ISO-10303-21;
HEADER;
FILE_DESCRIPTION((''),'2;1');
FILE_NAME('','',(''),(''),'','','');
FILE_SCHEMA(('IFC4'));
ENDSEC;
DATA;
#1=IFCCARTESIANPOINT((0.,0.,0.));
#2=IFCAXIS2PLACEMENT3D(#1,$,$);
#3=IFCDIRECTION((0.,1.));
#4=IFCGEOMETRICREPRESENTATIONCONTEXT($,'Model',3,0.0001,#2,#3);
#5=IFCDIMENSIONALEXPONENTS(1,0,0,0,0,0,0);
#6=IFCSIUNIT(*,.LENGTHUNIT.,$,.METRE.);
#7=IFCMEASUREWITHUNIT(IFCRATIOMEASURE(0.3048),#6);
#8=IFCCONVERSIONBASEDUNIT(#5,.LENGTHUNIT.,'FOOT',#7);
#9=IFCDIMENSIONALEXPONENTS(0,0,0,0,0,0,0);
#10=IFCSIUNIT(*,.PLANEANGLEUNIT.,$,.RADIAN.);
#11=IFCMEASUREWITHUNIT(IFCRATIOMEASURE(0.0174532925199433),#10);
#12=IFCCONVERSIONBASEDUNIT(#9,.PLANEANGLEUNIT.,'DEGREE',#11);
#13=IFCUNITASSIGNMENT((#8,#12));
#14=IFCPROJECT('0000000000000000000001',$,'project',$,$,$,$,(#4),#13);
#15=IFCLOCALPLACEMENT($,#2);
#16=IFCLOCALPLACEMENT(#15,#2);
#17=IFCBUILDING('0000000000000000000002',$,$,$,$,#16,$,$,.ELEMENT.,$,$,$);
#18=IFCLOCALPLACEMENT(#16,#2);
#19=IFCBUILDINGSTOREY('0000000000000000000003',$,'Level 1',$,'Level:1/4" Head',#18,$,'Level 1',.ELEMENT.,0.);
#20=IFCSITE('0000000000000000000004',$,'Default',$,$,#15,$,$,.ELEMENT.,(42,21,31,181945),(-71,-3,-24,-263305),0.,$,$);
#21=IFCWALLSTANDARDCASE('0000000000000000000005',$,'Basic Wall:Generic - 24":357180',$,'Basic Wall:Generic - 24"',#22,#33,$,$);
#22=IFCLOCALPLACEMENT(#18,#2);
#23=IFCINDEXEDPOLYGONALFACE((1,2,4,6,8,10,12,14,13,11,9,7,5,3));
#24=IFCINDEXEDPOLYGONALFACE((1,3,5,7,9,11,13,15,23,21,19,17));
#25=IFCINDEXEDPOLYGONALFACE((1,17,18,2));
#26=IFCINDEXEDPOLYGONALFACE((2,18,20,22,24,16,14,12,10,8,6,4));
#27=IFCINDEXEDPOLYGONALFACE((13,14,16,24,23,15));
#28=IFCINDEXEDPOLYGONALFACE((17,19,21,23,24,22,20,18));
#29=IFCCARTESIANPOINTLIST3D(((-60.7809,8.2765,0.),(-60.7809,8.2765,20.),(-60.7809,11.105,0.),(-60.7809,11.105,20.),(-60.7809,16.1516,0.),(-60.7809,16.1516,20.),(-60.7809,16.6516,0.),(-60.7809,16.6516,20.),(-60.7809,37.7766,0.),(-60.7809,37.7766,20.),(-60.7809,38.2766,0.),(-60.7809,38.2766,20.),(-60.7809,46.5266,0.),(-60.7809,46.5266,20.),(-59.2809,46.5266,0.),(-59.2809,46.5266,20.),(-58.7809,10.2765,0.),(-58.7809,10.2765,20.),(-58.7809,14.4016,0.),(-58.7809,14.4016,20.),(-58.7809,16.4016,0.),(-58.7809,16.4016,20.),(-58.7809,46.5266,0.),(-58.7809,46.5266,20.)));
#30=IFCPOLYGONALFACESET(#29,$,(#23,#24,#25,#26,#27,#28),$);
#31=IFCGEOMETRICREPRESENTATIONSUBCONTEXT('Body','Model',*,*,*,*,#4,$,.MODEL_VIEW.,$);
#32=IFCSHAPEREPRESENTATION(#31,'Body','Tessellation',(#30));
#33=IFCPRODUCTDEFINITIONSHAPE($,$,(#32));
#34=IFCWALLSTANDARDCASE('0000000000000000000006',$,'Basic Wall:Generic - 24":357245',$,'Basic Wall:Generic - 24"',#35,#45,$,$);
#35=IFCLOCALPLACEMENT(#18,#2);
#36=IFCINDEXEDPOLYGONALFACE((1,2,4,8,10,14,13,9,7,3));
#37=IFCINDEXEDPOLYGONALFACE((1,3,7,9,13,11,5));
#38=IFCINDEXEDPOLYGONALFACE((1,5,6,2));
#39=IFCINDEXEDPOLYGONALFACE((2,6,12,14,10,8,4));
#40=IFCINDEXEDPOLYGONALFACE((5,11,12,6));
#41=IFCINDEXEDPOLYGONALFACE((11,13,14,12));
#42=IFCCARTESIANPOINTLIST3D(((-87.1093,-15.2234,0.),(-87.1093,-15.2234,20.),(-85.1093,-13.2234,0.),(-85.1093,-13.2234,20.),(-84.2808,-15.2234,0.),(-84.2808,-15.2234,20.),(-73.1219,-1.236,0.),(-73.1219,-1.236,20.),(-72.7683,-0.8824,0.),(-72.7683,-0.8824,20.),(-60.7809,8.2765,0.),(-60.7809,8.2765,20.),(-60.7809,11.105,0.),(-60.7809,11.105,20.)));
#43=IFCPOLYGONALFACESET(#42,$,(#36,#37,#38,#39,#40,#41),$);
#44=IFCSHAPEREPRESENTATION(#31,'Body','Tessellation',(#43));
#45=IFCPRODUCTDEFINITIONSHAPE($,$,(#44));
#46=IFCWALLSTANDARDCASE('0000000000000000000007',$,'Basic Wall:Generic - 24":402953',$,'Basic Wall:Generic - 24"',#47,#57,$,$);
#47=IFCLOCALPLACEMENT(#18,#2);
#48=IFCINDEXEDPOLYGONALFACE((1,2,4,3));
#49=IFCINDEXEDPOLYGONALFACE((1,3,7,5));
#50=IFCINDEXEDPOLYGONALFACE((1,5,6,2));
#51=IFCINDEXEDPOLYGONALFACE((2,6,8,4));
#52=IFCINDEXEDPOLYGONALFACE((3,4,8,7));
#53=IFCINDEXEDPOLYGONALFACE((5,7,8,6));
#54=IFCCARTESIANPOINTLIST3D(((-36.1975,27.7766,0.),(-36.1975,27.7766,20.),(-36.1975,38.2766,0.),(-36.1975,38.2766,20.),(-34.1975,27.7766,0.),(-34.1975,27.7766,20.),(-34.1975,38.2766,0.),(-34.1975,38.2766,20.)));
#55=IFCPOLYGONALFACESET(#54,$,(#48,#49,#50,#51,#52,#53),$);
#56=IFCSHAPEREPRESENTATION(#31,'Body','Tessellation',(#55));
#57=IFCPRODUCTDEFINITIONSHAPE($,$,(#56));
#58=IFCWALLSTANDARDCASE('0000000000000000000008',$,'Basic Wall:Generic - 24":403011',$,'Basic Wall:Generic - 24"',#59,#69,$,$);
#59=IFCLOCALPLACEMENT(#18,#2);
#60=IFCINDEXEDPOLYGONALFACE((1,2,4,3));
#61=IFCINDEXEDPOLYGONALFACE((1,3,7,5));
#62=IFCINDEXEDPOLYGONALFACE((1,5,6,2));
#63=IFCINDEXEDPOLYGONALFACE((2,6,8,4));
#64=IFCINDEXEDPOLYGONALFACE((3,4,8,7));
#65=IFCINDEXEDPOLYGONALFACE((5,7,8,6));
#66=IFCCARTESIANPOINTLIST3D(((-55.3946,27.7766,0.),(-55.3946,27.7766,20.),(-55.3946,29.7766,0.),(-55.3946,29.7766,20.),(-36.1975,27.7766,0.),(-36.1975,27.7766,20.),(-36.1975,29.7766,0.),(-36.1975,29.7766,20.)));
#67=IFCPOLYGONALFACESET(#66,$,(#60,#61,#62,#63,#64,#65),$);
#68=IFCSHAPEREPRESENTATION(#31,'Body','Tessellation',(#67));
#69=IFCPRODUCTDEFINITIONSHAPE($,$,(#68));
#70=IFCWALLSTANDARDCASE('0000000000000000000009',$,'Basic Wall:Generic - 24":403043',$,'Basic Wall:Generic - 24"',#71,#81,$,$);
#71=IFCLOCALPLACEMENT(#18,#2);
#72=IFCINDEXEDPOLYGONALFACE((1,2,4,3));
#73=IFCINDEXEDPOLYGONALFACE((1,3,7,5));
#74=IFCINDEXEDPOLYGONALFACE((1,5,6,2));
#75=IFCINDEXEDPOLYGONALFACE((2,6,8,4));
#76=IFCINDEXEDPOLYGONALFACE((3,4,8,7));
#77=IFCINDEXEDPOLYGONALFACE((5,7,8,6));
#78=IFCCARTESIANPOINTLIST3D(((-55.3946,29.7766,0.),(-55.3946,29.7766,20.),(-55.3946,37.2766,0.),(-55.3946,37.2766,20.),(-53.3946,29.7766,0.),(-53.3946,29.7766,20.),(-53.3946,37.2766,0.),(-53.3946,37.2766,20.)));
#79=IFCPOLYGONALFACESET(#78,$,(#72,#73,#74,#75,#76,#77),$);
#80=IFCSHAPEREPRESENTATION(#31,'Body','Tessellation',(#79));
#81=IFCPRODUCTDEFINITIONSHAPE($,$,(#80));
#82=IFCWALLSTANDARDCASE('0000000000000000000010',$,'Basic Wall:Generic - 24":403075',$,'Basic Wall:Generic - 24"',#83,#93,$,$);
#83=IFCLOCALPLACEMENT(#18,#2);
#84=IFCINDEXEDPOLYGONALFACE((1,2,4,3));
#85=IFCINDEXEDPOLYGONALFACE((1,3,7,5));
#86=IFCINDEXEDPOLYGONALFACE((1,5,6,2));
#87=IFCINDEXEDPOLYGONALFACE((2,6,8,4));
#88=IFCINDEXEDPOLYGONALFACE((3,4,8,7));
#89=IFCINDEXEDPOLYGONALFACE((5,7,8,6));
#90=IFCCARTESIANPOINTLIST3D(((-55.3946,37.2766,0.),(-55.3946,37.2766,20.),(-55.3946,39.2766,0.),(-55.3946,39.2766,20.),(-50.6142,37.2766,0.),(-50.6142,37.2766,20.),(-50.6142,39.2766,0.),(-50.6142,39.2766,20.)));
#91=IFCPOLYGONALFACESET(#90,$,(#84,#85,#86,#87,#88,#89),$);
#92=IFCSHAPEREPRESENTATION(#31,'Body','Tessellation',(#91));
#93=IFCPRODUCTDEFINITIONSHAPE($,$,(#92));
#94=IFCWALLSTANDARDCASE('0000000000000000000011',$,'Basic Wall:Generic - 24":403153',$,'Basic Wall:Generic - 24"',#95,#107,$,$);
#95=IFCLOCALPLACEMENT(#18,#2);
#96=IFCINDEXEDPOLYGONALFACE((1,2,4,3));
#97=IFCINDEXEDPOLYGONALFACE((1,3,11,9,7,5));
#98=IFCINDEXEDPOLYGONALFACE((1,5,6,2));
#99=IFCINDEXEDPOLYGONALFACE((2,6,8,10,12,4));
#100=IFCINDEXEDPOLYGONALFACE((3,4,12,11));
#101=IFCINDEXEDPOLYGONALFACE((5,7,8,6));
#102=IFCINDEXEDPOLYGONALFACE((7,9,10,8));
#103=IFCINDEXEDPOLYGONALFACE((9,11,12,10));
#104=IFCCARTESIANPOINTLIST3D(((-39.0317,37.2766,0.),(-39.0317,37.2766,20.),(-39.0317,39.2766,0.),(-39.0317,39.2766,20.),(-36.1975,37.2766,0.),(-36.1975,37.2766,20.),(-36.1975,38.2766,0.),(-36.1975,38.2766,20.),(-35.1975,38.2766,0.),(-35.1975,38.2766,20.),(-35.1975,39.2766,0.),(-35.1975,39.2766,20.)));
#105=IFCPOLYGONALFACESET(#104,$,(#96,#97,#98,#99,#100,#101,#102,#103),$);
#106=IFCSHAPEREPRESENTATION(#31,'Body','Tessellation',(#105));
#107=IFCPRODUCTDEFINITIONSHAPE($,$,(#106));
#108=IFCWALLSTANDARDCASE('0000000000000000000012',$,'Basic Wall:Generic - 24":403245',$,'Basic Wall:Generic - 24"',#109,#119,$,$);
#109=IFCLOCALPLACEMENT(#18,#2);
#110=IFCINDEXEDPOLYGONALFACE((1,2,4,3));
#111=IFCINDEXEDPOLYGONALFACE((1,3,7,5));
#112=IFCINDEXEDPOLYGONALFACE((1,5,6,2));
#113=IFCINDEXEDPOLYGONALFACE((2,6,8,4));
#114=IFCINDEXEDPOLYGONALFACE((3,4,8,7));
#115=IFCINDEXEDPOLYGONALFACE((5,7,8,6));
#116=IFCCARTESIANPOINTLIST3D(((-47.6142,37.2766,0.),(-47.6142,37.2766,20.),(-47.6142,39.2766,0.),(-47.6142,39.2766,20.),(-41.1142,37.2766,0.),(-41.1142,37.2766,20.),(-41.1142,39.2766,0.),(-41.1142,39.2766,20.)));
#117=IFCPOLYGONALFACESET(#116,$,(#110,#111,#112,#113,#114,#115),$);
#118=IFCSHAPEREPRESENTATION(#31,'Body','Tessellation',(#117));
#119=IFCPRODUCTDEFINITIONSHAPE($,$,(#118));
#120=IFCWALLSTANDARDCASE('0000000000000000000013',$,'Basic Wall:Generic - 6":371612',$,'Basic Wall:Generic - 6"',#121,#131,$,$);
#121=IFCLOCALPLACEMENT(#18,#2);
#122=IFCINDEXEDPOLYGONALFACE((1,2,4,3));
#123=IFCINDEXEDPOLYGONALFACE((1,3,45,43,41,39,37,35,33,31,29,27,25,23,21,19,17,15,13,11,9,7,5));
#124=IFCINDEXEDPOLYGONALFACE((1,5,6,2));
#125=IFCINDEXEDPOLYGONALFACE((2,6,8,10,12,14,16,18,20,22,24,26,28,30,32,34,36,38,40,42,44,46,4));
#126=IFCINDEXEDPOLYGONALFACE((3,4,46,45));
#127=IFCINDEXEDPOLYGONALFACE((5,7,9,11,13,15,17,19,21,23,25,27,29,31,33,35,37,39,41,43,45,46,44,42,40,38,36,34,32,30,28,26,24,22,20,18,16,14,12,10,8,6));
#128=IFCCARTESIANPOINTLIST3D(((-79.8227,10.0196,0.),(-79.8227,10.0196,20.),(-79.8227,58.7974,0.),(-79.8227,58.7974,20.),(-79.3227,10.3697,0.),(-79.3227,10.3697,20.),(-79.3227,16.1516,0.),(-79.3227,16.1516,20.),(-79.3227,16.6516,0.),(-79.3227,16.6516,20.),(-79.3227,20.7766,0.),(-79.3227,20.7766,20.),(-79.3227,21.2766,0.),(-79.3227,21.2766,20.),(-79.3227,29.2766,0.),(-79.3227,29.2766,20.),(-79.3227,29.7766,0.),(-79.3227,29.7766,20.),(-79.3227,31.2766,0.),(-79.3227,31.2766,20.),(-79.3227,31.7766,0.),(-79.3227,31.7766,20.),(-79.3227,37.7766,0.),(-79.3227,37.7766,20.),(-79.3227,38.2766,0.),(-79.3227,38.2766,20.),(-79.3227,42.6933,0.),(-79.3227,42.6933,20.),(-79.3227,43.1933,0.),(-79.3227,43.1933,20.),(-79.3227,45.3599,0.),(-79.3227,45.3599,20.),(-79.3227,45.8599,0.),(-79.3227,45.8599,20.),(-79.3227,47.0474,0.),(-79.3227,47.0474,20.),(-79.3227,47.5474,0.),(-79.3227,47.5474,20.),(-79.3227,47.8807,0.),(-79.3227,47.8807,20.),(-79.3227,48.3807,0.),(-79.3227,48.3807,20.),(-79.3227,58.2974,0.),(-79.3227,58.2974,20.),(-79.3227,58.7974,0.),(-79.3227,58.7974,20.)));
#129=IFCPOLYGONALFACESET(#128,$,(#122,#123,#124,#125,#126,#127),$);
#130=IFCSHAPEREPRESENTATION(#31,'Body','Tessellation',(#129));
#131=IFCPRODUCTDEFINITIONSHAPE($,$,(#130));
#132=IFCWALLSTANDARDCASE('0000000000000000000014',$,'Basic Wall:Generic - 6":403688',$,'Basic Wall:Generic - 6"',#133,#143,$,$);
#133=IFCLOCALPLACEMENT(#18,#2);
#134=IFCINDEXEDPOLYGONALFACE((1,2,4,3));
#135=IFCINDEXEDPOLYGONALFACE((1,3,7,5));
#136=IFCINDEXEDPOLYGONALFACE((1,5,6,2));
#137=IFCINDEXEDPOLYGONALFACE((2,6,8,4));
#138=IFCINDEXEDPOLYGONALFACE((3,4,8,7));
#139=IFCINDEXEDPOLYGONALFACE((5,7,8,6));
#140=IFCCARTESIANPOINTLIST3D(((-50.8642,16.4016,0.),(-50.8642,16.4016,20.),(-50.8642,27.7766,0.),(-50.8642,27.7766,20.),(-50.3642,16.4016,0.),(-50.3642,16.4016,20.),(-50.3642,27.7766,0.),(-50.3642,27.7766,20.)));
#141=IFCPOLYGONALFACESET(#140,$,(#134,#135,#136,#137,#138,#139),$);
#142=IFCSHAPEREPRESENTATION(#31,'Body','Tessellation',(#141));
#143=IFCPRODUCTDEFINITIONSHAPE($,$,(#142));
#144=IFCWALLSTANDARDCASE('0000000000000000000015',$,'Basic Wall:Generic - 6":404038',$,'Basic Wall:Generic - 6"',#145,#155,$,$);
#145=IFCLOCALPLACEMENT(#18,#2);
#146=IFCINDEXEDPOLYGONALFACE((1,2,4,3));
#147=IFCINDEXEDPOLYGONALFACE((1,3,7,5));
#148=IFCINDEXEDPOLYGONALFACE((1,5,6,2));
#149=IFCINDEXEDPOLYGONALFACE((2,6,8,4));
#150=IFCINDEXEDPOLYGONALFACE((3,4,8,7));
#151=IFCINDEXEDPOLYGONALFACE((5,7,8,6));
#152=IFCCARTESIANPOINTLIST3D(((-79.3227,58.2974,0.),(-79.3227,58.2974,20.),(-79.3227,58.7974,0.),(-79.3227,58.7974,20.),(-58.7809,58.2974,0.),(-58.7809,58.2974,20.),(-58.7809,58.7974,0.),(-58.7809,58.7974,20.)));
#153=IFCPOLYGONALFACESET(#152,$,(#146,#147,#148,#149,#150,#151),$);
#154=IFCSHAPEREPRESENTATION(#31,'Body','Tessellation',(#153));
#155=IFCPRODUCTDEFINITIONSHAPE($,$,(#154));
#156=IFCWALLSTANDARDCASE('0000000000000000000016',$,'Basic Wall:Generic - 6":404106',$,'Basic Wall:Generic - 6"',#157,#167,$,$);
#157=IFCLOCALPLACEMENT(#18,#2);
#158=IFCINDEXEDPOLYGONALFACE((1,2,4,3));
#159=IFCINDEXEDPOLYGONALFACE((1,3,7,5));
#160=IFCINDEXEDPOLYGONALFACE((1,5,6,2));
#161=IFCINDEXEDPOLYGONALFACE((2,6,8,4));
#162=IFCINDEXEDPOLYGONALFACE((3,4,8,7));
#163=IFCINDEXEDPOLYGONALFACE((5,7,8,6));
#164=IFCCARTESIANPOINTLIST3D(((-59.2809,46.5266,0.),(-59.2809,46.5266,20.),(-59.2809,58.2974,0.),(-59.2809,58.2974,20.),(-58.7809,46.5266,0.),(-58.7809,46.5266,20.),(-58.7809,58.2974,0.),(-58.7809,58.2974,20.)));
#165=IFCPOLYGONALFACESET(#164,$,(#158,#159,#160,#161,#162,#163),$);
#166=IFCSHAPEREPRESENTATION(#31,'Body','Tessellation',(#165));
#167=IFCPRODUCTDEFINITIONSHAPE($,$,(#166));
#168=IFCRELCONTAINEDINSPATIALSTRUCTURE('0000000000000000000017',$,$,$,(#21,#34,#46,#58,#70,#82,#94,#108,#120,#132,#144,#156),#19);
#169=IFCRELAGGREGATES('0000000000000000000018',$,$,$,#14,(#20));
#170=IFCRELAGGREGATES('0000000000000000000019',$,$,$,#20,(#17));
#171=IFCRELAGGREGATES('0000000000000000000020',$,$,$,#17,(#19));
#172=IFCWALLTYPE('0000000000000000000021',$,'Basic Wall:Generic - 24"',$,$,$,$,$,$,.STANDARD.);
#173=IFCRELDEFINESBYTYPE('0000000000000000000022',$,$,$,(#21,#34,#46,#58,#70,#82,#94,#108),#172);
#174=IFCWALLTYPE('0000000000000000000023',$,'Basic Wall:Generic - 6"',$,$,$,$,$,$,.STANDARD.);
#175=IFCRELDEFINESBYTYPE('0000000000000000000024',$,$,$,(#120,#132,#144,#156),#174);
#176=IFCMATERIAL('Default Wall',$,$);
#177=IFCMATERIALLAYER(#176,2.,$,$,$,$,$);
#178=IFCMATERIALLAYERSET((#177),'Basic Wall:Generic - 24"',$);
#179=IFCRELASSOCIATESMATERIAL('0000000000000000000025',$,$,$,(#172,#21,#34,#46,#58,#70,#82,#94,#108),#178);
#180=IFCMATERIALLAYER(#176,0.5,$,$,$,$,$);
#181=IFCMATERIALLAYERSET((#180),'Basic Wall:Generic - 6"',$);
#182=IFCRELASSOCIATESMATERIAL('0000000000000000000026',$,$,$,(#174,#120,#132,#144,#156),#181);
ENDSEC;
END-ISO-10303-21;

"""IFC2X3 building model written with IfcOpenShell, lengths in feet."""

from ifc_helpers import new_model, entity, si_unit, converted_unit, direction, frame, frame_2d, origin, place, context, subcontext, project, spatial, polyline, rectangle, outline, extrude, material, layer, layer_set, layer_usage, type_object, element, save


model = new_model("IFC2X3")

# Units and contexts
model_context = context("Model", 3, precision=0.0001, world=origin(), true_north=direction((0.0, 1.0)))
body_context = subcontext(model_context, "Body", "Model", "MODEL_VIEW")
ifc_project = project(units=[converted_unit("LENGTHUNIT", "FOOT", entity("IfcRatioMeasure", 0.3048), si_unit("LENGTHUNIT", "METRE"), dimensions=[1, 0, 0, 0, 0, 0, 0]), converted_unit("PLANEANGLEUNIT", "DEGREE", entity("IfcRatioMeasure", 0.0174532925199433), si_unit("PLANEANGLEUNIT", "RADIAN"), dimensions=[0, 0, 0, 0, 0, 0, 0])], contexts=[model_context])

# Site, building, storey
site_placement = place(None, origin())
site = spatial("IfcSite", under=ifc_project, at=site_placement, Name="Default", CompositionType="ELEMENT", RefLatitude=(42, 21, 31, 181945), RefLongitude=(-71, -3, -24, -263305), RefElevation=0.0)
building_placement = place(site_placement, origin())
building = spatial("IfcBuilding", under=site, at=building_placement, CompositionType="ELEMENT")
storey_placement = place(building_placement, origin())
storey = spatial("IfcBuildingStorey", under=building, at=storey_placement, Name="Level 1", ObjectType="Level:1/4\" Head", LongName="Level 1", CompositionType="ELEMENT", Elevation=0.0)

# Walls
ifc_material = material(Name="Default Wall")
ifc_layer_1 = layer(ifc_material, 2.0)
ifc_layer_set_1 = layer_set([ifc_layer_1], Name="Basic Wall:Generic - 24\"")
ifc_layer_usage_1 = layer_usage(ifc_layer_set_1, "AXIS2", "NEGATIVE", 1.0)
wall_type_1 = type_object("IfcWallType", Name="Basic Wall:Generic - 24\"", PredefinedType="STANDARD", material=ifc_layer_set_1)
wall_1_placement = place(storey_placement, frame((-59.7809, 46.5266, 0.0), z_axis=(0.0, 0.0, 1.0), x_axis=(0.0, -1.0, 0.0)))
element("IfcWallStandardCase", 1, at=wall_1_placement, inside=storey, type_object=wall_type_1, material=ifc_layer_usage_1, Name="Basic Wall:Generic - 24\":357180", ObjectType="Basic Wall:Generic - 24\"", context=body_context, shape_type="SweptSolid", body=[
    extrude(outline(polyline([(38.25, -1.0), (36.25, 1.0), (32.125, 1.0), (30.125, 1.0), (0.0, 1.0), (0.0, 0.5), (0.0, -1.0), (8.25, -1.0), (8.75, -1.0), (29.875, -1.0), (30.375, -1.0), (35.4216, -1.0), (38.25, -1.0)])), origin(), (0.0, 0.0, 1.0), 20.0),
])
ifc_layer_usage_2 = layer_usage(ifc_layer_set_1, "AXIS2", "NEGATIVE", 1.0)
wall_2_placement = place(storey_placement, frame((-60.0738, 10.3979, 0.0), z_axis=(0.0, 0.0, 1.0), x_axis=(-0.707107, -0.707107, 0.0)))
element("IfcWallStandardCase", 2, at=wall_2_placement, inside=storey, type_object=wall_type_1, material=ifc_layer_usage_2, Name="Basic Wall:Generic - 24\":357245", ObjectType="Basic Wall:Generic - 24\"", context=body_context, shape_type="SweptSolid", body=[
    extrude(outline(polyline([(37.234, -1.0), (35.234, 1.0), (2.0, 1.0), (0.0, -1.0), (16.9528, -1.0), (17.4528, -1.0), (34.4056, -1.0), (37.234, -1.0)])), origin(), (0.0, 0.0, 1.0), 20.0),
])
ifc_layer_usage_3 = layer_usage(ifc_layer_set_1, "AXIS2", "NEGATIVE", 1.0)
wall_3_placement = place(storey_placement, frame((-35.1975, 38.2766, 0.0), z_axis=(0.0, 0.0, 1.0), x_axis=(0.0, -1.0, 0.0)))
element("IfcWallStandardCase", 3, at=wall_3_placement, inside=storey, type_object=wall_type_1, material=ifc_layer_usage_3, Name="Basic Wall:Generic - 24\":402953", ObjectType="Basic Wall:Generic - 24\"", context=body_context, shape_type="SweptSolid", body=[
    extrude(rectangle(XDim=10.5, YDim=2.0, at=frame_2d((5.25, 0.0), x_axis=(-1.0, 0.0))), origin(), (0.0, 0.0, 1.0), 20.0),
])
ifc_layer_usage_4 = layer_usage(ifc_layer_set_1, "AXIS2", "NEGATIVE", 1.0)
wall_4_placement = place(storey_placement, frame((-36.1975, 28.7766, 0.0), z_axis=(0.0, 0.0, 1.0), x_axis=(-1.0, 0.0, 0.0)))
element("IfcWallStandardCase", 4, at=wall_4_placement, inside=storey, type_object=wall_type_1, material=ifc_layer_usage_4, Name="Basic Wall:Generic - 24\":403011", ObjectType="Basic Wall:Generic - 24\"", context=body_context, shape_type="SweptSolid", body=[
    extrude(rectangle(XDim=19.1971, YDim=2.0, at=frame_2d((9.5986, 0.0), x_axis=(-1.0, 0.0))), origin(), (0.0, 0.0, 1.0), 20.0),
])
ifc_layer_usage_5 = layer_usage(ifc_layer_set_1, "AXIS2", "NEGATIVE", 1.0)
wall_5_placement = place(storey_placement, frame((-54.3946, 29.7766, 0.0), z_axis=(0.0, 0.0, 1.0), x_axis=(0.0, 1.0, 0.0)))
element("IfcWallStandardCase", 5, at=wall_5_placement, inside=storey, type_object=wall_type_1, material=ifc_layer_usage_5, Name="Basic Wall:Generic - 24\":403043", ObjectType="Basic Wall:Generic - 24\"", context=body_context, shape_type="SweptSolid", body=[
    extrude(rectangle(XDim=7.5, YDim=2.0, at=frame_2d((3.75, 0.0), x_axis=(-1.0, 0.0))), origin(), (0.0, 0.0, 1.0), 20.0),
])
ifc_layer_usage_6 = layer_usage(ifc_layer_set_1, "AXIS2", "NEGATIVE", 1.0)
wall_6_placement = place(storey_placement, frame((-55.3946, 38.2766, 0.0)))
element("IfcWallStandardCase", 6, at=wall_6_placement, inside=storey, type_object=wall_type_1, material=ifc_layer_usage_6, Name="Basic Wall:Generic - 24\":403075", ObjectType="Basic Wall:Generic - 24\"", context=body_context, shape_type="SweptSolid", body=[
    extrude(rectangle(XDim=4.7804, YDim=2.0, at=frame_2d((2.3902, 0.0), x_axis=(-1.0, 0.0))), origin(), (0.0, 0.0, 1.0), 20.0),
])
ifc_layer_usage_7 = layer_usage(ifc_layer_set_1, "AXIS2", "NEGATIVE", 1.0)
wall_7_placement = place(storey_placement, frame((-35.1975, 38.2766, 0.0), z_axis=(0.0, 0.0, 1.0), x_axis=(-1.0, 0.0, 0.0)))
element("IfcWallStandardCase", 7, at=wall_7_placement, inside=storey, type_object=wall_type_1, material=ifc_layer_usage_7, Name="Basic Wall:Generic - 24\":403153", ObjectType="Basic Wall:Generic - 24\"", context=body_context, shape_type="SweptSolid", body=[
    extrude(outline(polyline([(3.8342, -1.0), (3.8342, 1.0), (1.0, 1.0), (1.0, 0.0), (0.0, 0.0), (0.0, -1.0), (3.8342, -1.0)])), origin(), (0.0, 0.0, 1.0), 20.0),
])
ifc_layer_usage_8 = layer_usage(ifc_layer_set_1, "AXIS2", "NEGATIVE", 1.0)
wall_8_placement = place(storey_placement, frame((-47.6142, 38.2766, 0.0)))
element("IfcWallStandardCase", 8, at=wall_8_placement, inside=storey, type_object=wall_type_1, material=ifc_layer_usage_8, Name="Basic Wall:Generic - 24\":403245", ObjectType="Basic Wall:Generic - 24\"", context=body_context, shape_type="SweptSolid", body=[
    extrude(rectangle(XDim=6.5, YDim=2.0, at=frame_2d((3.25, 0.0), x_axis=(-1.0, 0.0))), origin(), (0.0, 0.0, 1.0), 20.0),
])
ifc_layer_2 = layer(ifc_material, 0.5)
ifc_layer_set_2 = layer_set([ifc_layer_2], Name="Basic Wall:Generic - 6\"")
ifc_layer_usage_9 = layer_usage(ifc_layer_set_2, "AXIS2", "NEGATIVE", 0.25)
wall_type_2 = type_object("IfcWallType", Name="Basic Wall:Generic - 6\"", PredefinedType="STANDARD", material=ifc_layer_set_2)
wall_9_placement = place(storey_placement, frame((-79.5727, 10.0196, 0.0), z_axis=(0.0, 0.0, 1.0), x_axis=(0.0, 1.0, 0.0)))
element("IfcWallStandardCase", 9, at=wall_9_placement, inside=storey, type_object=wall_type_2, material=ifc_layer_usage_9, Name="Basic Wall:Generic - 6\":371612", ObjectType="Basic Wall:Generic - 6\"", context=body_context, shape_type="SweptSolid", body=[
    extrude(outline(polyline([(48.7778, -0.25), (48.7778, 0.25), (0.0, 0.25), (0.3501, -0.25), (6.1319, -0.25), (6.6319, -0.25), (10.7569, -0.25), (11.2569, -0.25), (19.2569, -0.25), (19.7569, -0.25), (21.2569, -0.25), (21.7569, -0.25), (27.7569, -0.25), (28.2569, -0.25), (32.6737, -0.25), (33.1737, -0.25), (35.3403, -0.25), (35.8403, -0.25), (37.0278, -0.25), (37.5278, -0.25), (37.8611, -0.25), (38.3611, -0.25), (48.2778, -0.25), (48.7778, -0.25)])), origin(), (0.0, 0.0, 1.0), 20.0),
])
ifc_layer_usage_10 = layer_usage(ifc_layer_set_2, "AXIS2", "NEGATIVE", 0.25)
wall_10_placement = place(storey_placement, frame((-50.6142, 16.4016, 0.0), z_axis=(0.0, 0.0, 1.0), x_axis=(0.0, 1.0, 0.0)))
element("IfcWallStandardCase", 10, at=wall_10_placement, inside=storey, type_object=wall_type_2, material=ifc_layer_usage_10, Name="Basic Wall:Generic - 6\":403688", ObjectType="Basic Wall:Generic - 6\"", context=body_context, shape_type="SweptSolid", body=[
    extrude(rectangle(XDim=11.375, YDim=0.5, at=frame_2d((5.6875, 0.0), x_axis=(-1.0, 0.0))), origin(), (0.0, 0.0, 1.0), 20.0),
])
ifc_layer_usage_11 = layer_usage(ifc_layer_set_2, "AXIS2", "NEGATIVE", 0.25)
wall_11_placement = place(storey_placement, frame((-79.3227, 58.5474, 0.0)))
element("IfcWallStandardCase", 11, at=wall_11_placement, inside=storey, type_object=wall_type_2, material=ifc_layer_usage_11, Name="Basic Wall:Generic - 6\":404038", ObjectType="Basic Wall:Generic - 6\"", context=body_context, shape_type="SweptSolid", body=[
    extrude(rectangle(XDim=20.5418, YDim=0.5, at=frame_2d((10.2709, 0.0), x_axis=(-1.0, 0.0))), origin(), (0.0, 0.0, 1.0), 20.0),
])
ifc_layer_usage_12 = layer_usage(ifc_layer_set_2, "AXIS2", "NEGATIVE", 0.25)
wall_12_placement = place(storey_placement, frame((-59.0309, 58.2974, 0.0), z_axis=(0.0, 0.0, 1.0), x_axis=(0.0, -1.0, 0.0)))
element("IfcWallStandardCase", 12, at=wall_12_placement, inside=storey, type_object=wall_type_2, material=ifc_layer_usage_12, Name="Basic Wall:Generic - 6\":404106", ObjectType="Basic Wall:Generic - 6\"", context=body_context, shape_type="SweptSolid", body=[
    extrude(rectangle(XDim=11.7708, YDim=0.5, at=frame_2d((5.8854, 0.0), x_axis=(-1.0, 0.0))), origin(), (0.0, 0.0, 1.0), 20.0),
])

save(model, "model.ifc")
